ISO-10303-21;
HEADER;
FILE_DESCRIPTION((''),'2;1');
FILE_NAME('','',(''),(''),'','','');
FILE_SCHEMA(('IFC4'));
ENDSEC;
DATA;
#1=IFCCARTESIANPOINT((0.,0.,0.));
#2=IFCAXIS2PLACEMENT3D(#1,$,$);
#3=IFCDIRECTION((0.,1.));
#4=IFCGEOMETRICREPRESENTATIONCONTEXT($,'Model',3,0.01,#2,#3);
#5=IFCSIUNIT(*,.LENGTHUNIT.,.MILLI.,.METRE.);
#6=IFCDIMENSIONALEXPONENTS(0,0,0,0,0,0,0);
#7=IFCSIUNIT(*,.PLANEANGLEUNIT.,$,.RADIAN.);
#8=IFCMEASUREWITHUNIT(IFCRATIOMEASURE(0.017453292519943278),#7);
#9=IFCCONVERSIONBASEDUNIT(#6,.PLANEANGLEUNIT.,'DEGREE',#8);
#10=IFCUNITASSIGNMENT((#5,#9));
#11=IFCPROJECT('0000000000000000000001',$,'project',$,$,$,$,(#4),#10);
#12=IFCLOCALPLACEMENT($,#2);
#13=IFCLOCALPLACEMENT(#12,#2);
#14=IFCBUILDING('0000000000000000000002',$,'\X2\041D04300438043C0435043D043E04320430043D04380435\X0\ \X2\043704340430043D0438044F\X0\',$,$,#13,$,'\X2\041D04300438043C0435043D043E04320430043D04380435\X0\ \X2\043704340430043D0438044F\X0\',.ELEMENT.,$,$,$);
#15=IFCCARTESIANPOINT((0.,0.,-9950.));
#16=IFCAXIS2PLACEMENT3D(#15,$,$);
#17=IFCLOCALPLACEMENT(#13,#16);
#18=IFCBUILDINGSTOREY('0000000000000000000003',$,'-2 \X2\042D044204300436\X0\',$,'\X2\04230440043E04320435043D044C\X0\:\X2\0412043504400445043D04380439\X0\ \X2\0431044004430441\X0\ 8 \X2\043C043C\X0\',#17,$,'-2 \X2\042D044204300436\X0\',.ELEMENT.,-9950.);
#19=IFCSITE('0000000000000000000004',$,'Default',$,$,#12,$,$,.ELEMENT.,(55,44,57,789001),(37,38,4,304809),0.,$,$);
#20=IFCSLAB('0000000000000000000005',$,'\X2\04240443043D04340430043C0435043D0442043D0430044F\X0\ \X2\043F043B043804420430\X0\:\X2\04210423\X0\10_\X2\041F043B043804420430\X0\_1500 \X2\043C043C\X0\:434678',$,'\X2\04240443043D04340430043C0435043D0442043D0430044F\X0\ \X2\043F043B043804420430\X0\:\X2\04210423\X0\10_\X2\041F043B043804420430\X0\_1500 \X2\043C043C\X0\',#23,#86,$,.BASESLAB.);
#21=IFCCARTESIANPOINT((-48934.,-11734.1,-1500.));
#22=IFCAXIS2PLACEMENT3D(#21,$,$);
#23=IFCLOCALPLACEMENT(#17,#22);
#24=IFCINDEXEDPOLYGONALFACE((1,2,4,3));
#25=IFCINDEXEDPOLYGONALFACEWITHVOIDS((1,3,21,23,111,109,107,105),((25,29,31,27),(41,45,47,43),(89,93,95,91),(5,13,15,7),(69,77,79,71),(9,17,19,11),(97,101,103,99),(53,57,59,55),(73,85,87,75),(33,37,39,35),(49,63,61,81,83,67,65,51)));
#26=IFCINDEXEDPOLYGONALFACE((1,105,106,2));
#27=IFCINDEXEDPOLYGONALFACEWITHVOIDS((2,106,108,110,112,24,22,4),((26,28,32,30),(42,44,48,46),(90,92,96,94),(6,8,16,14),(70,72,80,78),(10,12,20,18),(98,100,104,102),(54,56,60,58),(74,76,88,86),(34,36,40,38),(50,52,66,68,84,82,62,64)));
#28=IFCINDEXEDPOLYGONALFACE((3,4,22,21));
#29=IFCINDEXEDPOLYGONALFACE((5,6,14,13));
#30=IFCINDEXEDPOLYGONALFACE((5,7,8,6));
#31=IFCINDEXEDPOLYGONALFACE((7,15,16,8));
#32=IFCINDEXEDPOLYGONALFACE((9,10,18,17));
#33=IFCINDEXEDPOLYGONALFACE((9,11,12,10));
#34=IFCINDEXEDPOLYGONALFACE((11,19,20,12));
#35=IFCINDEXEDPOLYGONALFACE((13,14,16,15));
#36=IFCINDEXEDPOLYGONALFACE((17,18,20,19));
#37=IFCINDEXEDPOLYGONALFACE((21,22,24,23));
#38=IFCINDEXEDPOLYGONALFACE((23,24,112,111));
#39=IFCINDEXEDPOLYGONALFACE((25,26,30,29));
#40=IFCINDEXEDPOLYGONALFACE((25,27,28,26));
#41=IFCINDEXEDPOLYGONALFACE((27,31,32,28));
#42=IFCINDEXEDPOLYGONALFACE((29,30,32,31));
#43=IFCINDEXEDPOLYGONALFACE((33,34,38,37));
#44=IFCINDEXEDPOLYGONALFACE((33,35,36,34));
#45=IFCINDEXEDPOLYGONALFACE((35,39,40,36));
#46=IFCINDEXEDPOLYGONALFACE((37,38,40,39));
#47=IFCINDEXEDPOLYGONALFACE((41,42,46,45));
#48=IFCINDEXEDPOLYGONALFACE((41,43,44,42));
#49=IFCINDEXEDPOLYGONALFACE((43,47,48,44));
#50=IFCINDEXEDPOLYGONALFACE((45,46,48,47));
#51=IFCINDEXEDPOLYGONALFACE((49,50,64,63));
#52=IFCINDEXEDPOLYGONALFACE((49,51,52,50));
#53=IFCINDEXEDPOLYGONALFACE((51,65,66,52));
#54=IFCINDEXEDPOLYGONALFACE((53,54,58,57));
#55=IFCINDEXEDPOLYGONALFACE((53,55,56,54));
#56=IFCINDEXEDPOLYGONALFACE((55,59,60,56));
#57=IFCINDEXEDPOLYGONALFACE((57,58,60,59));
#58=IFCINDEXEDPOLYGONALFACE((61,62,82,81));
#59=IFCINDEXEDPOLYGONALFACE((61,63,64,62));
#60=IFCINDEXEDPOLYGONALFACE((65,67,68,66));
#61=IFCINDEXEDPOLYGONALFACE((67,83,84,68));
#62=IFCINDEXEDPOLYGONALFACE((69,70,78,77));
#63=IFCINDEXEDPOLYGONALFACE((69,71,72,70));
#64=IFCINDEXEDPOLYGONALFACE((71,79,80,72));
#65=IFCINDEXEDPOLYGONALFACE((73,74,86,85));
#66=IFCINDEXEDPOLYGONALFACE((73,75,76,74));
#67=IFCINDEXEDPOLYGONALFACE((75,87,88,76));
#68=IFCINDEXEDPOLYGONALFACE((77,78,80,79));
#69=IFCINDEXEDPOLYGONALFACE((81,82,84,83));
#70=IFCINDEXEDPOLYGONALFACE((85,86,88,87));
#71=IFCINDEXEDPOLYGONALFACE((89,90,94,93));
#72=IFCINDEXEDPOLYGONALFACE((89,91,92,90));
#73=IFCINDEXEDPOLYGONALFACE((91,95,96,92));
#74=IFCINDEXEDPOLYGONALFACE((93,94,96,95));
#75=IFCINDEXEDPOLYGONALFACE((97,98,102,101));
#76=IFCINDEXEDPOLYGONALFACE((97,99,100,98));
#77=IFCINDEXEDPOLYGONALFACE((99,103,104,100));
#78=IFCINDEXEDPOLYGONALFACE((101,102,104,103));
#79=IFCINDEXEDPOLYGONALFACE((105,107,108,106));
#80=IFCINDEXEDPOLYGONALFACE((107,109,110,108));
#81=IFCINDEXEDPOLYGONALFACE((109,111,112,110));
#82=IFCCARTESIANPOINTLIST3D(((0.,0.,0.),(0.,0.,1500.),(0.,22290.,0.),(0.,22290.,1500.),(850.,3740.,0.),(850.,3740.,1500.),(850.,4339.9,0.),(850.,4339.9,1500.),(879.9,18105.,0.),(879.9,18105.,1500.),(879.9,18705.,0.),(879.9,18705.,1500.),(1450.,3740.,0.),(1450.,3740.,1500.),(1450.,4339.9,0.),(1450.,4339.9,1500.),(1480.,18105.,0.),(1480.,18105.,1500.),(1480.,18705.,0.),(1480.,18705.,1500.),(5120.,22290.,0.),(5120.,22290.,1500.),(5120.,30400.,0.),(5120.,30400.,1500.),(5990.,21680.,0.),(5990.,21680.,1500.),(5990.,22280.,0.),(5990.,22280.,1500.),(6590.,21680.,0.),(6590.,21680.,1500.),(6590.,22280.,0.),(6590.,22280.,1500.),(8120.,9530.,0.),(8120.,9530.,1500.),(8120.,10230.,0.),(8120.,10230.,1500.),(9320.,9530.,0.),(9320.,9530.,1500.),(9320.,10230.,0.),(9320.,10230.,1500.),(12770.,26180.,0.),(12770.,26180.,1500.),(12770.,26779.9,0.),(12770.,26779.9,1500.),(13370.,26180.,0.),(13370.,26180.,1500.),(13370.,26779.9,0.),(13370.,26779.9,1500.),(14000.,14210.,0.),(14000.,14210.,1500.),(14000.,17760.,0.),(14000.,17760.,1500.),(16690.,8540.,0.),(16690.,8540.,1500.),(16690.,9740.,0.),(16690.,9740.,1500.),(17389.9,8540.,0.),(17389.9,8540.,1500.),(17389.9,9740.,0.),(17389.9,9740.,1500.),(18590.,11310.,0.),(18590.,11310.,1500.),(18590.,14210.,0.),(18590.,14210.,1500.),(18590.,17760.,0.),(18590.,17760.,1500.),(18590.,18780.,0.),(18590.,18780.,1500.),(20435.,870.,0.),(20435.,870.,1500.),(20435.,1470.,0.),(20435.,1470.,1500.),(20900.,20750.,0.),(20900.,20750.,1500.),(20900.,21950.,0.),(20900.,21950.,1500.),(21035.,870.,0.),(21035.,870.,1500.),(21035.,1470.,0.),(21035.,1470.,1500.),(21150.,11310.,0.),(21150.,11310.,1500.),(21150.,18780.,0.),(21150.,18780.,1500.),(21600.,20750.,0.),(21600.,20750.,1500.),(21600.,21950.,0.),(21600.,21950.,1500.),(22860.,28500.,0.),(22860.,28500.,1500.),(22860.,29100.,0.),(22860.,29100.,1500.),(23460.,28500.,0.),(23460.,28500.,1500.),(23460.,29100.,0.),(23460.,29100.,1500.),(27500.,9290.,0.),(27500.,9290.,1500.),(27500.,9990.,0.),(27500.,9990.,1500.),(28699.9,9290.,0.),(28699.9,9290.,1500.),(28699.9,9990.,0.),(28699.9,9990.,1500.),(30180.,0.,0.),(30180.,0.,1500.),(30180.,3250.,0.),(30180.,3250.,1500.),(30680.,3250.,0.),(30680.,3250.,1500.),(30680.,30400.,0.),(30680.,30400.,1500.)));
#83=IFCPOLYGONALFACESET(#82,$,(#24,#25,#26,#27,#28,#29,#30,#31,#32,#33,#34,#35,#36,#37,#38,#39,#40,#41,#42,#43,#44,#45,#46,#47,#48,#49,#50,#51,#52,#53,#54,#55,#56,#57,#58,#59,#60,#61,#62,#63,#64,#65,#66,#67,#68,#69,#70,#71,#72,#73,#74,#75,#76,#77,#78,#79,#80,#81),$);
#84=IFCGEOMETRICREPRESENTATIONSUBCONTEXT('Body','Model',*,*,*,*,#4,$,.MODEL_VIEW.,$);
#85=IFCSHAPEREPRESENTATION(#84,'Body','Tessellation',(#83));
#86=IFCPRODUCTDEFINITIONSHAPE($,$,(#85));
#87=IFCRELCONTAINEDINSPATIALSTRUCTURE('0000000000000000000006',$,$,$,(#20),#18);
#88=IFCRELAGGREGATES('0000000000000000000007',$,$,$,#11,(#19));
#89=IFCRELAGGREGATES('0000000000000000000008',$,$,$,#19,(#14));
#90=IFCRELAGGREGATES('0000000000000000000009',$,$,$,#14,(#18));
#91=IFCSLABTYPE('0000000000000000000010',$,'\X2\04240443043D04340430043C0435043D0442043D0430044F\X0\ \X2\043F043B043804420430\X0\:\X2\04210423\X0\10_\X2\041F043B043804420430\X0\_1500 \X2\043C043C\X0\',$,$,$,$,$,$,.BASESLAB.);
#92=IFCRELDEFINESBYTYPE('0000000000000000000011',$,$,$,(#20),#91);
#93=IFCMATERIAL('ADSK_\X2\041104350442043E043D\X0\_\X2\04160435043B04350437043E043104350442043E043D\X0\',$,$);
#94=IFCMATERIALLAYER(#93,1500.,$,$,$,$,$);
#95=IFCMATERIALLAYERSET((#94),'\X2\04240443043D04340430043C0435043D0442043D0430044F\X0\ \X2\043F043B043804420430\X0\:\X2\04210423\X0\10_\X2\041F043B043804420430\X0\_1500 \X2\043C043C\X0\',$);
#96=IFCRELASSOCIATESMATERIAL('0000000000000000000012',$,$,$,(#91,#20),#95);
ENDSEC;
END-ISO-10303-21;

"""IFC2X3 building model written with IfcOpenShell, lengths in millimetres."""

from ifc_helpers import new_model, entity, si_unit, converted_unit, direction, frame, origin, origin_2d_with_axis, place, context, subcontext, project, spatial, polyline, rectangle, outline, extrude, material, layer, layer_set, layer_usage, type_object, element, save


model = new_model("IFC2X3")

# Units and contexts
model_context = context("Model", 3, precision=0.01, world=origin(), true_north=direction((0.0, 1.0)))
body_context = subcontext(model_context, "Body", "Model", "MODEL_VIEW")
ifc_project = project(units=[si_unit("LENGTHUNIT", "METRE", prefix="MILLI"), converted_unit("PLANEANGLEUNIT", "DEGREE", entity("IfcRatioMeasure", 0.017453292519943278), si_unit("PLANEANGLEUNIT", "RADIAN"), dimensions=[0, 0, 0, 0, 0, 0, 0])], contexts=[model_context])

# Site, building, storey
site_placement = place(None, origin())
site = spatial("IfcSite", under=ifc_project, at=site_placement, Name="Default", CompositionType="ELEMENT", RefLatitude=(55, 44, 57, 789001), RefLongitude=(37, 38, 4, 304809), RefElevation=0.0)
building_placement = place(site_placement, origin())
building = spatial("IfcBuilding", under=site, at=building_placement, Name="Наименование здания", LongName="Наименование здания", CompositionType="ELEMENT")
storey_placement = place(building_placement, frame((0.0, 0.0, -9950.0)))
storey = spatial("IfcBuildingStorey", under=building, at=storey_placement, Name="-2 Этаж", ObjectType="Уровень:Верхний брус 8 мм", LongName="-2 Этаж", CompositionType="ELEMENT", Elevation=-9950.0)

# Shared definitions
ifc_material = material(Name="ADSK_Бетон_Железобетон")

# Slab, openings
ifc_layer_1 = layer(ifc_material, 1500.0)
ifc_layer_set_1 = layer_set([ifc_layer_1], Name="Фундаментная плита:СУ10_Плита_1500 мм")
ifc_layer_usage_1 = layer_usage(ifc_layer_set_1, "AXIS3", "POSITIVE", 0.0)
slab_type_1 = type_object("IfcSlabType", Name="Фундаментная плита:СУ10_Плита_1500 мм", PredefinedType="BASESLAB", material=ifc_layer_set_1)
slab_1_placement = place(storey_placement, frame((-48934.0, -11734.1, -1500.0)))
slab_1 = element("IfcSlab", 1, at=slab_1_placement, inside=storey, type_object=slab_type_1, material=ifc_layer_usage_1, Name="Фундаментная плита:СУ10_Плита_1500 мм:434678", ObjectType="Фундаментная плита:СУ10_Плита_1500 мм", PredefinedType="BASESLAB", context=body_context, shape_type="SweptSolid", body=[
    extrude(outline(polyline([(-15340.0, 15200.0), (-15340.0, -11950.1), (-14840.0, -11950.1), (-14840.0, -15200.0), (15340.0, -15200.0), (15340.0, 7090.0), (10220.0, 7090.0), (10220.0, 15200.0), (-15340.0, 15200.0)])), frame((15340.0, 15200.0, 1500.0), z_axis=(0.0, 0.0, -1.0), x_axis=(-1.0, 0.0, 0.0)), (0.0, 0.0, 1.0), 1500.0),
])
opening_1_placement = place(slab_1_placement, frame((18082.5, 15515.0, 1500.0)))
element("IfcOpeningElement", 2, at=opening_1_placement, cuts=slab_1, ObjectType="Opening", context=body_context, shape_type="SweptSolid", body=[
    extrude(outline(polyline([(-4082.5, 2245.0), (-4082.5, -1305.0), (507.5, -1305.0), (507.5, -4205.0), (3067.5, -4205.0), (3067.5, 3265.0), (507.5, 3265.0), (507.5, 2245.0), (-4082.5, 2245.0)])), origin(), (0.0, 0.0, -1.0), 1500.0),
])
opening_2_placement = place(slab_1_placement, frame((20735.0, 1170.0, 1500.0)))
element("IfcOpeningElement", 3, at=opening_2_placement, cuts=slab_1, ObjectType="Opening", context=body_context, shape_type="SweptSolid", body=[
    extrude(rectangle(XDim=600.1, YDim=600.0, at=origin_2d_with_axis()), frame((0.0, 0.0, 0.0), z_axis=(0.0, 0.0, -1.0), x_axis=(0.0, 1.0, 0.0)), (0.0, 0.0, 1.0), 1500.0),
])
opening_3_placement = place(slab_1_placement, frame((28099.9, 9640.0, 1500.0)))
element("IfcOpeningElement", 4, at=opening_3_placement, cuts=slab_1, ObjectType="Opening", context=body_context, shape_type="SweptSolid", body=[
    extrude(rectangle(XDim=700.0, YDim=1200.0, at=origin_2d_with_axis()), frame((0.0, 0.0, 0.0), z_axis=(0.0, 0.0, -1.0), x_axis=(0.0, 1.0, 0.0)), (0.0, 0.0, 1.0), 1500.0),
])
opening_4_placement = place(slab_1_placement, frame((17040.0, 9140.0, 1500.0)))
element("IfcOpeningElement", 5, at=opening_4_placement, cuts=slab_1, ObjectType="Opening", context=body_context, shape_type="SweptSolid", body=[
    extrude(rectangle(XDim=1200.0, YDim=700.0, at=origin_2d_with_axis()), frame((0.0, 0.0, 0.0), z_axis=(0.0, 0.0, -1.0), x_axis=(0.0, 1.0, 0.0)), (0.0, 0.0, 1.0), 1500.0),
])
opening_5_placement = place(slab_1_placement, frame((1150.0, 4040.0, 1500.0)))
element("IfcOpeningElement", 6, at=opening_5_placement, cuts=slab_1, ObjectType="Opening", context=body_context, shape_type="SweptSolid", body=[
    extrude(rectangle(XDim=600.0, YDim=600.1, at=origin_2d_with_axis()), frame((0.0, 0.0, 0.0), z_axis=(0.0, 0.0, -1.0), x_axis=(0.0, 1.0, 0.0)), (0.0, 0.0, 1.0), 1500.0),
])
opening_6_placement = place(slab_1_placement, frame((8720.0, 9880.0, 1500.0)))
element("IfcOpeningElement", 7, at=opening_6_placement, cuts=slab_1, ObjectType="Opening", context=body_context, shape_type="SweptSolid", body=[
    extrude(rectangle(XDim=700.0, YDim=1200.0, at=origin_2d_with_axis()), frame((0.0, 0.0, 0.0), z_axis=(0.0, 0.0, -1.0), x_axis=(0.0, 1.0, 0.0)), (0.0, 0.0, 1.0), 1500.0),
])
opening_7_placement = place(slab_1_placement, frame((21250.0, 21350.0, 1500.0)))
element("IfcOpeningElement", 8, at=opening_7_placement, cuts=slab_1, ObjectType="Opening", context=body_context, shape_type="SweptSolid", body=[
    extrude(rectangle(XDim=1200.0, YDim=700.0, at=origin_2d_with_axis()), frame((0.0, 0.0, 0.0), z_axis=(0.0, 0.0, -1.0), x_axis=(0.0, 1.0, 0.0)), (0.0, 0.0, 1.0), 1500.0),
])
opening_8_placement = place(slab_1_placement, frame((13070.0, 26480.0, 1500.0)))
element("IfcOpeningElement", 9, at=opening_8_placement, cuts=slab_1, ObjectType="Opening", context=body_context, shape_type="SweptSolid", body=[
    extrude(rectangle(XDim=600.0, YDim=600.0, at=origin_2d_with_axis()), frame((0.0, 0.0, 0.0), z_axis=(0.0, 0.0, -1.0), x_axis=(0.0, -1.0, 0.0)), (0.0, 0.0, 1.0), 1500.0),
])
opening_9_placement = place(slab_1_placement, frame((6290.0, 21980.0, 1500.0)))
element("IfcOpeningElement", 10, at=opening_9_placement, cuts=slab_1, ObjectType="Opening", context=body_context, shape_type="SweptSolid", body=[
    extrude(rectangle(XDim=600.0, YDim=600.0, at=origin_2d_with_axis()), frame((0.0, 0.0, 0.0), z_axis=(0.0, 0.0, -1.0), x_axis=(0.0, -1.0, 0.0)), (0.0, 0.0, 1.0), 1500.0),
])
opening_10_placement = place(slab_1_placement, frame((1180.0, 18405.0, 1500.0)))
element("IfcOpeningElement", 11, at=opening_10_placement, cuts=slab_1, ObjectType="Opening", context=body_context, shape_type="SweptSolid", body=[
    extrude(rectangle(XDim=600.1, YDim=600.1, at=origin_2d_with_axis()), frame((0.0, 0.0, 0.0), z_axis=(0.0, 0.0, -1.0), x_axis=(0.0, -1.0, 0.0)), (0.0, 0.0, 1.0), 1500.0),
])
opening_11_placement = place(slab_1_placement, frame((23160.0, 28800.0, 1500.0)))
element("IfcOpeningElement", 12, at=opening_11_placement, cuts=slab_1, ObjectType="Opening", context=body_context, shape_type="SweptSolid", body=[
    extrude(rectangle(XDim=600.1, YDim=600.0, at=origin_2d_with_axis()), frame((0.0, 0.0, 0.0), z_axis=(0.0, 0.0, -1.0), x_axis=(0.0, -1.0, 0.0)), (0.0, 0.0, 1.0), 1500.0),
])

save(model, "model.ifc")
